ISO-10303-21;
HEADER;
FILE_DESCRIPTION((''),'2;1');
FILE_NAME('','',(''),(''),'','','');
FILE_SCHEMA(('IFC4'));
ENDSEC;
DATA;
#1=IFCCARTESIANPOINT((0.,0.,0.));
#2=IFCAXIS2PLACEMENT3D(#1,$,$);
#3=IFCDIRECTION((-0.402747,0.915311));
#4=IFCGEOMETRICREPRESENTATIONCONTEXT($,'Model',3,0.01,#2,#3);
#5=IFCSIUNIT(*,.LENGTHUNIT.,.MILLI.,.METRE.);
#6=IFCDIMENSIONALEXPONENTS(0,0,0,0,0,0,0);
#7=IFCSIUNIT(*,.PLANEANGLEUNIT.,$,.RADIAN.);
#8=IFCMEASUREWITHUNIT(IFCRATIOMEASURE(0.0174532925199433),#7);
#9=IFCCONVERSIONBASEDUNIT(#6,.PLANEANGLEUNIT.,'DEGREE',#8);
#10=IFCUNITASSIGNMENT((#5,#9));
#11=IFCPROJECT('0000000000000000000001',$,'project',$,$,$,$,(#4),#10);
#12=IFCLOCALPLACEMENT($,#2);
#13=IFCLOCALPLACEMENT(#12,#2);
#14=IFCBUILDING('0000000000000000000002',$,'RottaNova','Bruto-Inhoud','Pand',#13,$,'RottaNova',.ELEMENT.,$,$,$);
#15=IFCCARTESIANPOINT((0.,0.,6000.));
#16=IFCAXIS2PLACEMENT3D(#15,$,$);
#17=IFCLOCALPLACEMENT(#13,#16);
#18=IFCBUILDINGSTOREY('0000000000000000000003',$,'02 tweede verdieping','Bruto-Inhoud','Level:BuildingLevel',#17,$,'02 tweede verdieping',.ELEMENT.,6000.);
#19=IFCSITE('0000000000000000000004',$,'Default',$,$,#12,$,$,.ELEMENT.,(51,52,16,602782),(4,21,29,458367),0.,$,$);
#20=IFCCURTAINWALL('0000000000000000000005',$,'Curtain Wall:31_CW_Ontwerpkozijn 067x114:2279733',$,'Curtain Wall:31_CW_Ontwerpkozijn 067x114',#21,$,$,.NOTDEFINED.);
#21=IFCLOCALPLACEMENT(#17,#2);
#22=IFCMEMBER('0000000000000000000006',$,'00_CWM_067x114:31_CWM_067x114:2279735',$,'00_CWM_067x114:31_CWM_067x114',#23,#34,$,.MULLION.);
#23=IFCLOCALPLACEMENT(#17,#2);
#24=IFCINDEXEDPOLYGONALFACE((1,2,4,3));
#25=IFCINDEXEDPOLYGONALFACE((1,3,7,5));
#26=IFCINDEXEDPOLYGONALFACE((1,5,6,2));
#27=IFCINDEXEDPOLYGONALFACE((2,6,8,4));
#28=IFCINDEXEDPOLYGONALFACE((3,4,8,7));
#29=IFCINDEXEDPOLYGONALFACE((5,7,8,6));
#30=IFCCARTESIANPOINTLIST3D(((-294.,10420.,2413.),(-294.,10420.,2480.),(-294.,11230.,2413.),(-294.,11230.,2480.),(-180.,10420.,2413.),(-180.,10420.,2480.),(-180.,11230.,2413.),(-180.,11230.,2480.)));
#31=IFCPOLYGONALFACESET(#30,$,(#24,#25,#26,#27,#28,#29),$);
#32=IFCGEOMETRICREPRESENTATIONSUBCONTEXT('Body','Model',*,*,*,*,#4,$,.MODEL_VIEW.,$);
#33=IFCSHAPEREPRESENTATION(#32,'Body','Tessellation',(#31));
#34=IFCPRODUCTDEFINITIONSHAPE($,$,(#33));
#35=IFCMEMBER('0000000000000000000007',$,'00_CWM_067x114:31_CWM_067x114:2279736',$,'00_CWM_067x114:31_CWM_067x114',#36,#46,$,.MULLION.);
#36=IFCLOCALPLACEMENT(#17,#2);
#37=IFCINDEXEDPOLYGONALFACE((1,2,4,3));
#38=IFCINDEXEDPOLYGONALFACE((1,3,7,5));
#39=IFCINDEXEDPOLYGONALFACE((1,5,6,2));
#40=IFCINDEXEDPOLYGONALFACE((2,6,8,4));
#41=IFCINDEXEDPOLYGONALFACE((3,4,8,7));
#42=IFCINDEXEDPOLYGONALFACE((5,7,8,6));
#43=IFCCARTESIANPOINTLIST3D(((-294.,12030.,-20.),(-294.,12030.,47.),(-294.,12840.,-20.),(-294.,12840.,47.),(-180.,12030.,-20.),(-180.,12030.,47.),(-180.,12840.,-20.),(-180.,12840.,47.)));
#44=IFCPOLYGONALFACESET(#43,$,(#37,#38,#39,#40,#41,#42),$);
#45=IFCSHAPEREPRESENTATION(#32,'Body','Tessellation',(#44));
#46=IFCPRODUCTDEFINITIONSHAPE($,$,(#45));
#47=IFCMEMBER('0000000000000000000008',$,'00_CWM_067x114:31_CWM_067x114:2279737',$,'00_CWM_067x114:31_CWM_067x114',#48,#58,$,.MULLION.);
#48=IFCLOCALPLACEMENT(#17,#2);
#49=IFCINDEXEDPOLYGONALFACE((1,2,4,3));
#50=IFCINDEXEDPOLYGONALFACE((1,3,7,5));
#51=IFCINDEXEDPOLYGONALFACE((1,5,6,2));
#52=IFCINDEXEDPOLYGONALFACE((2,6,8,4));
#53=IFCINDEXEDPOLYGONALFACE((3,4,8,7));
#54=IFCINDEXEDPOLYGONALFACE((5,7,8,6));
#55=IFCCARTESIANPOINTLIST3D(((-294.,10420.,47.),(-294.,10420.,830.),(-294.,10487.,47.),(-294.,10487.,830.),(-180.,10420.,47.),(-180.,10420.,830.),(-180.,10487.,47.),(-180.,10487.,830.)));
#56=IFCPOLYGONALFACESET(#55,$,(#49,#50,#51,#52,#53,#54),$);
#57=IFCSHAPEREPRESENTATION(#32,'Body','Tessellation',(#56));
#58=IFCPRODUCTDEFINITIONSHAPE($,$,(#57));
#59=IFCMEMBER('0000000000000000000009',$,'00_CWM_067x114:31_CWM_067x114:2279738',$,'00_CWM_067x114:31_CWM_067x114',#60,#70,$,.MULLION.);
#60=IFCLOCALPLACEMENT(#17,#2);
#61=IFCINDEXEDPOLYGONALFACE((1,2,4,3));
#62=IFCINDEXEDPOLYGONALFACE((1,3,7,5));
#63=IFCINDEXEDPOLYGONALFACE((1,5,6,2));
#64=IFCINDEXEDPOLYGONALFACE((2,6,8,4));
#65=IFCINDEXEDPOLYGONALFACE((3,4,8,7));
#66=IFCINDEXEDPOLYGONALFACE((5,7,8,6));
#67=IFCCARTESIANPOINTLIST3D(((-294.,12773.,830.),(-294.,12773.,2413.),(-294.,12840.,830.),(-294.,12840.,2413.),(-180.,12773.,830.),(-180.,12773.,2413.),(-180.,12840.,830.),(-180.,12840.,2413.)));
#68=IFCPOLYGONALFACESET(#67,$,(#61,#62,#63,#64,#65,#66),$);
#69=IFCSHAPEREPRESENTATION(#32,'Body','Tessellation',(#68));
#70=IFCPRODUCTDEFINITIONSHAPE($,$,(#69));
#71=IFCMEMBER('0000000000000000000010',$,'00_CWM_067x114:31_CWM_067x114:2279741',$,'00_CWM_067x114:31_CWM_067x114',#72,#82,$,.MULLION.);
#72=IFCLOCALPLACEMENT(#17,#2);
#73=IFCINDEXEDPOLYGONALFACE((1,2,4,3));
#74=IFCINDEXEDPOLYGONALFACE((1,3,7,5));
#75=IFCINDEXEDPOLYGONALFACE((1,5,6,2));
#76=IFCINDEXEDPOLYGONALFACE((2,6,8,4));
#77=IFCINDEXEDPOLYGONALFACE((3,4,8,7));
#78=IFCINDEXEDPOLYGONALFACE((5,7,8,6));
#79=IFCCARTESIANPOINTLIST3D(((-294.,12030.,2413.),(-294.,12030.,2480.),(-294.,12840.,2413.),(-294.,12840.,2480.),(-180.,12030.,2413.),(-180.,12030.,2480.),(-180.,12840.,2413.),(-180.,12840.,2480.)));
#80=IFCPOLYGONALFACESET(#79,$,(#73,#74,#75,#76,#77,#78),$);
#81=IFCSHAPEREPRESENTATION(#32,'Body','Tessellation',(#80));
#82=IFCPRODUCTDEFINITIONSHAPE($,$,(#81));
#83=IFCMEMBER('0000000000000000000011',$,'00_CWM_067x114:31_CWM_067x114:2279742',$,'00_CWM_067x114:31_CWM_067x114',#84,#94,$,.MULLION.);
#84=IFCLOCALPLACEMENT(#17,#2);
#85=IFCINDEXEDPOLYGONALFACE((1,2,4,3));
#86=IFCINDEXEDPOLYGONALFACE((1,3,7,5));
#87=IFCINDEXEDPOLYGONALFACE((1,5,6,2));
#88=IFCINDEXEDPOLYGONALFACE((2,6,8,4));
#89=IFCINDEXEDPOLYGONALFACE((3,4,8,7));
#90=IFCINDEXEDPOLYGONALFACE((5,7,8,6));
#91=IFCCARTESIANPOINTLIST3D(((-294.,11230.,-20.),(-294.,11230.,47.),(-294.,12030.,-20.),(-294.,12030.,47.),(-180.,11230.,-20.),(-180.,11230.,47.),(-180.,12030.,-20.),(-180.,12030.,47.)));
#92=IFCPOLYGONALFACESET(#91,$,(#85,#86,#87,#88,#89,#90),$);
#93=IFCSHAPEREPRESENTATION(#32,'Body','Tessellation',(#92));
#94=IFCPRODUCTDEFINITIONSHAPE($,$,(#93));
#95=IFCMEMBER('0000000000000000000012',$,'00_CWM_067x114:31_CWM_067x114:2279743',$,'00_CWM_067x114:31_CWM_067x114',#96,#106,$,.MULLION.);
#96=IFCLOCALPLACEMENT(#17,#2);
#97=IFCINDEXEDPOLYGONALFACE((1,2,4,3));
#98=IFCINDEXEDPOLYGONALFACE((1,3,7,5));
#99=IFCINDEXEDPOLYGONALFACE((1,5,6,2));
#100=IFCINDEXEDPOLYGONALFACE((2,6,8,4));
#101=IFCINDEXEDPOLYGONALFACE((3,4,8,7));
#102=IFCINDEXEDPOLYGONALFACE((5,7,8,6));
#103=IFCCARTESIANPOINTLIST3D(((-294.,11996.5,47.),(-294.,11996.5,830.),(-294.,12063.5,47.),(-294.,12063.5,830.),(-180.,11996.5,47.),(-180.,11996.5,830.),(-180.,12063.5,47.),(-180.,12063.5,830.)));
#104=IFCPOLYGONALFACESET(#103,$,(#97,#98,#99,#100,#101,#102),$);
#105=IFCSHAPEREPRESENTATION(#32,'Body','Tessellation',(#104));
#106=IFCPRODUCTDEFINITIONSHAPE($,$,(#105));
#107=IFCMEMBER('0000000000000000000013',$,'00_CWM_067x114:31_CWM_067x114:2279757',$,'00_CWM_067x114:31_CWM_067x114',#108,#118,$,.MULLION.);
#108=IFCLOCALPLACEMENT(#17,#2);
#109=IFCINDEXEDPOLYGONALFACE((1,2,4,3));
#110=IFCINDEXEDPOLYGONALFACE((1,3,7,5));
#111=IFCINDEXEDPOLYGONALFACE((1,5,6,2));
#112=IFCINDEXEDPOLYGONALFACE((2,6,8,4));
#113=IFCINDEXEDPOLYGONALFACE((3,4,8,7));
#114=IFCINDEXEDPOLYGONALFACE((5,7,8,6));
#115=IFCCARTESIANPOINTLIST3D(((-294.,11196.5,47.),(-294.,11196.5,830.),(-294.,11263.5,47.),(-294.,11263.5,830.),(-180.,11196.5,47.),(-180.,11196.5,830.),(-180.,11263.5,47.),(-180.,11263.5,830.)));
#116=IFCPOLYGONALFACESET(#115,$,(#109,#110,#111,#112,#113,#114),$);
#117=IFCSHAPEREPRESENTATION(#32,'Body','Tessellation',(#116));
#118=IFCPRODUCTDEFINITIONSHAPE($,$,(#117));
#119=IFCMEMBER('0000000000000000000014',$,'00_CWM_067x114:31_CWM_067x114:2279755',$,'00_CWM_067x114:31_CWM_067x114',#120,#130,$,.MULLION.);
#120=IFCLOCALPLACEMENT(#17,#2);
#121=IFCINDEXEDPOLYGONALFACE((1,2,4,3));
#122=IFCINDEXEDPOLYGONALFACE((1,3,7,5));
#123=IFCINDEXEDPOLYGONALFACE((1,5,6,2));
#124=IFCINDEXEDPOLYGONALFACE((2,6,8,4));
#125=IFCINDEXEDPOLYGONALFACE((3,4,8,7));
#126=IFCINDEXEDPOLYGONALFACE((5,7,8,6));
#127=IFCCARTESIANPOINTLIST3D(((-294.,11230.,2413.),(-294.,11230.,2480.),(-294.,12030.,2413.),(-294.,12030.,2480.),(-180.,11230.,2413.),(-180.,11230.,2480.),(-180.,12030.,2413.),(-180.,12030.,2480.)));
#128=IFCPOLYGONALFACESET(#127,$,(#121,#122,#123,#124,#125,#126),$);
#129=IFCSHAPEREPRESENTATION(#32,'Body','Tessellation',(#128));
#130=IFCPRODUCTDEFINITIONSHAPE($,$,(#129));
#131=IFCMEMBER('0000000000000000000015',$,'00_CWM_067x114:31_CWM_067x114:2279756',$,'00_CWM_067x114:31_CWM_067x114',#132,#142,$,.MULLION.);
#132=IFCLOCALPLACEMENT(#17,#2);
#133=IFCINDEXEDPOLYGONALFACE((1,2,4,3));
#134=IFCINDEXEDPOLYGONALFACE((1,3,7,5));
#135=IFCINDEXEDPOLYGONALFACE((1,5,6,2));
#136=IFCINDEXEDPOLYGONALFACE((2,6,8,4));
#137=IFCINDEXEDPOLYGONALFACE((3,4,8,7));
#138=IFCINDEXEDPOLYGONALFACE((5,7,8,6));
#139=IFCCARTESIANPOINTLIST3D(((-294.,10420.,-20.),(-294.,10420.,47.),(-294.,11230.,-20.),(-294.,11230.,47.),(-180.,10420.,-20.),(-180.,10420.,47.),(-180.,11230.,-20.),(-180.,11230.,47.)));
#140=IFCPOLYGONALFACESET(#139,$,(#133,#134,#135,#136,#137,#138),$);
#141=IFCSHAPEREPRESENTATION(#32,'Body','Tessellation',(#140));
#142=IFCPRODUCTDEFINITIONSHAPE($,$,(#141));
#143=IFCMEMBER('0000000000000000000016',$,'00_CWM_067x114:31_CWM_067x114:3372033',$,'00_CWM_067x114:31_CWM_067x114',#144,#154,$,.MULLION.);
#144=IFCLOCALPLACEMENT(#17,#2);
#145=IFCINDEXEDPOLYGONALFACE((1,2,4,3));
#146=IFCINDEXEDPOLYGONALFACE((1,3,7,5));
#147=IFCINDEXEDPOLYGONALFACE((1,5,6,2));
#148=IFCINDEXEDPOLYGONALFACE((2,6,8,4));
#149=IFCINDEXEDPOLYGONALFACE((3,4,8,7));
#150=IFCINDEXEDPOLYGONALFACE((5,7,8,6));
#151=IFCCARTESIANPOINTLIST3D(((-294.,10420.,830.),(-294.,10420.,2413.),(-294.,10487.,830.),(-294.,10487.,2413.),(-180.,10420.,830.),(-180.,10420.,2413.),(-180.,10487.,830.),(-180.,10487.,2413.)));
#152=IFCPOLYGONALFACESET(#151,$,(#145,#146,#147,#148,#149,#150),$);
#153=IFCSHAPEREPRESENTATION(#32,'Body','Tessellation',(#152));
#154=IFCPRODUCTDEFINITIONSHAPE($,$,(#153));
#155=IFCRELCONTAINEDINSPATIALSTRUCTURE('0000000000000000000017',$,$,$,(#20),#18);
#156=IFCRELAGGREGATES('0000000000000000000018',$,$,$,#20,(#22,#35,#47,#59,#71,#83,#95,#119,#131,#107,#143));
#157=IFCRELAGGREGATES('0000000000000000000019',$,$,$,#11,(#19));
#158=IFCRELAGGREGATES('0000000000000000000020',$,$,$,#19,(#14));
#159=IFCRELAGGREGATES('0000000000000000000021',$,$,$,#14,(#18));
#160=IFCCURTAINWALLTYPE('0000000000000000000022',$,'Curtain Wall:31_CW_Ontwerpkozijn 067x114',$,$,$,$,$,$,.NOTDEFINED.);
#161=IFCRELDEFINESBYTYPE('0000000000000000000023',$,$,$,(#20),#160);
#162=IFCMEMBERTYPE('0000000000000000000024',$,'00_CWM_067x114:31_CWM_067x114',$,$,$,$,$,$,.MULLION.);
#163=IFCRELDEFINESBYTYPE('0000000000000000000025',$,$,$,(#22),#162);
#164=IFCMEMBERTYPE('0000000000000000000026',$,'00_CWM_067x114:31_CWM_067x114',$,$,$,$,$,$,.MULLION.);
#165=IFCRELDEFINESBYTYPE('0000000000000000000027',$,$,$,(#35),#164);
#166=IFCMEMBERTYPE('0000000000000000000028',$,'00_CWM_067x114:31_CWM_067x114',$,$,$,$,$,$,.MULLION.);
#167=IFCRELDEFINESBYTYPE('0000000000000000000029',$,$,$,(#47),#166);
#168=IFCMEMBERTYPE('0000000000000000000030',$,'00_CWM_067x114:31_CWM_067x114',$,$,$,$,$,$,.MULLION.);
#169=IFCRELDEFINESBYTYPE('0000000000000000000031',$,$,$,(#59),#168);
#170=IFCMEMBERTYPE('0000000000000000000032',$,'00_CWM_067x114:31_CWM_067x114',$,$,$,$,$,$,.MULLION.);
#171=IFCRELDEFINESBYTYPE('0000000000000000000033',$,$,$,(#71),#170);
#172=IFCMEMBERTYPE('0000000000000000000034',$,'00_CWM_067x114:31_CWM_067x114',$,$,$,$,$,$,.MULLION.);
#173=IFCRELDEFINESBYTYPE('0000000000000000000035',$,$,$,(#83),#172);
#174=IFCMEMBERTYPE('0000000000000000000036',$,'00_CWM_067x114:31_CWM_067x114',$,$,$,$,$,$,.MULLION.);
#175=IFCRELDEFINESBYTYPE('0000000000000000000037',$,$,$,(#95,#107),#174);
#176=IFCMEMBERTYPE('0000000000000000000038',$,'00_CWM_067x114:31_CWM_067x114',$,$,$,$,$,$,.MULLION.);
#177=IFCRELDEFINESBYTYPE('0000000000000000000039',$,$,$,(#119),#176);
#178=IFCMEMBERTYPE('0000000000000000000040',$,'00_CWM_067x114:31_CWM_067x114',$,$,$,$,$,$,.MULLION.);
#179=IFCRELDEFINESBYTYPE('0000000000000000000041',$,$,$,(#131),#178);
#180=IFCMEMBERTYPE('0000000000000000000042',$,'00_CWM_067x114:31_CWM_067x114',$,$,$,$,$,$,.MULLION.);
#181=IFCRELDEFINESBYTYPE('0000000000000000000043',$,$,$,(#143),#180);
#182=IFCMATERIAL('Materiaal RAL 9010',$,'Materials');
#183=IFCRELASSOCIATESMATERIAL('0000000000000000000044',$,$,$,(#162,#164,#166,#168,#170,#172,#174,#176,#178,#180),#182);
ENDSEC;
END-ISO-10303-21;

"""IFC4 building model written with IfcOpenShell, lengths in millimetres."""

from ifc_helpers import new_model, entity, si_unit, converted_unit, direction, frame, origin, origin_2d_with_axis, place, context, subcontext, project, spatial, rectangle, extrude, source, transform, mapped, material, material_profile, profile_set, type_object, type_shapes, element, aggregate, save


model = new_model("IFC4")

# Units and contexts
model_context = context("Model", 3, precision=0.01, world=origin(), true_north=direction((-0.402747, 0.915311)))
body_context = subcontext(model_context, "Body", "Model", "MODEL_VIEW")
ifc_project = project(units=[si_unit("LENGTHUNIT", "METRE", prefix="MILLI"), converted_unit("PLANEANGLEUNIT", "DEGREE", entity("IfcRatioMeasure", 0.0174532925199433), si_unit("PLANEANGLEUNIT", "RADIAN"), dimensions=[0, 0, 0, 0, 0, 0, 0])], contexts=[model_context])

# Site, building, storey
site_placement = place(None, origin())
site = spatial("IfcSite", under=ifc_project, at=site_placement, Name="Default", CompositionType="ELEMENT", RefLatitude=(51, 52, 16, 602782), RefLongitude=(4, 21, 29, 458367), RefElevation=0.0)
building_placement = place(site_placement, origin())
building = spatial("IfcBuilding", under=site, at=building_placement, Name="RottaNova", Description="Bruto-Inhoud", ObjectType="Pand", LongName="RottaNova", CompositionType="ELEMENT")
storey_placement = place(building_placement, frame((0.0, 0.0, 6000.0)))
storey = spatial("IfcBuildingStorey", under=building, at=storey_placement, Name="02 tweede verdieping", Description="Bruto-Inhoud", ObjectType="Level:BuildingLevel", LongName="02 tweede verdieping", CompositionType="ELEMENT", Elevation=6000.0)

# Curtain wall, members
curtain_wall_type = type_object("IfcCurtainWallType", Name="Curtain Wall:31_CW_Ontwerpkozijn 067x114", PredefinedType="NOTDEFINED")
curtain_wall_1_placement = place(storey_placement, frame((0.0, 0.0, -6000.0)))
curtain_wall_1 = element("IfcCurtainWall", 1, at=curtain_wall_1_placement, inside=storey, type_object=curtain_wall_type, Name="Curtain Wall:31_CW_Ontwerpkozijn 067x114:2279733", ObjectType="Curtain Wall:31_CW_Ontwerpkozijn 067x114", PredefinedType="NOTDEFINED")
ifc_material_1 = material(Name="Materiaal RAL 9010", Category="Materials")
ifc_material_profile = material_profile(ifc_material_1, rectangle(XDim=114.0, YDim=67.0, at=origin_2d_with_axis()), Name="31_CWM_067x114")
ifc_profile_set = profile_set([ifc_material_profile], Name="31_CWM_067x114")
member_type_1 = type_object("IfcMemberType", Name="00_CWM_067x114:31_CWM_067x114", PredefinedType="MULLION", material=ifc_profile_set)
shared_shape_1 = source(origin(), body_context, "Body", "SweptSolid", [
    extrude(rectangle(XDim=114.0, YDim=67.0, at=origin_2d_with_axis()), frame((-33.5, 57.0, -810.0), z_axis=(0.0, 0.0, 1.0), x_axis=(0.0, -1.0, 0.0)), (0.0, 0.0, 1.0), 810.0),
])
type_shapes(member_type_1, [shared_shape_1])
member_1_placement = place(curtain_wall_1_placement, frame((-180.0, 10420.0, 8480.0), z_axis=(0.0, -1.0, 0.0), x_axis=(0.0, 0.0, 1.0)))
member_1 = element("IfcMember", 2, at=member_1_placement, type_object=member_type_1, Name="00_CWM_067x114:31_CWM_067x114:2279735", ObjectType="00_CWM_067x114:31_CWM_067x114", PredefinedType="MULLION", context=body_context, shape_type="MappedRepresentation", body=[
    mapped(shared_shape_1, transform((0.0, 0.0, 0.0), scale=1.0)),
])
member_type_2 = type_object("IfcMemberType", Name="00_CWM_067x114:31_CWM_067x114", PredefinedType="MULLION", material=ifc_profile_set)
shared_shape_2 = source(origin(), body_context, "Body", "SweptSolid", [
    extrude(rectangle(XDim=114.0, YDim=67.0, at=origin_2d_with_axis()), frame((-33.5, 57.0, -810.0), z_axis=(0.0, 0.0, 1.0), x_axis=(0.0, -1.0, 0.0)), (0.0, 0.0, 1.0), 810.0),
])
type_shapes(member_type_2, [shared_shape_2])
member_2_placement = place(curtain_wall_1_placement, frame((-180.0, 12840.0, 5980.0), z_axis=(0.0, 1.0, 0.0), x_axis=(0.0, 0.0, -1.0)))
member_2 = element("IfcMember", 3, at=member_2_placement, type_object=member_type_2, Name="00_CWM_067x114:31_CWM_067x114:2279736", ObjectType="00_CWM_067x114:31_CWM_067x114", PredefinedType="MULLION", context=body_context, shape_type="MappedRepresentation", body=[
    mapped(shared_shape_2, transform((0.0, 0.0, 0.0), scale=1.0)),
])
member_type_3 = type_object("IfcMemberType", Name="00_CWM_067x114:31_CWM_067x114", PredefinedType="MULLION", material=ifc_profile_set)
shared_shape_3 = source(origin(), body_context, "Body", "SweptSolid", [
    extrude(rectangle(XDim=114.0, YDim=67.0, at=origin_2d_with_axis()), frame((-33.5, 57.0, -783.0), z_axis=(0.0, 0.0, 1.0), x_axis=(0.0, -1.0, 0.0)), (0.0, 0.0, 1.0), 783.0),
])
type_shapes(member_type_3, [shared_shape_3])
member_3_placement = place(curtain_wall_1_placement, frame((-180.0, 10420.0, 6047.0), z_axis=(0.0, 0.0, -1.0), x_axis=(0.0, -1.0, 0.0)))
member_3 = element("IfcMember", 4, at=member_3_placement, type_object=member_type_3, Name="00_CWM_067x114:31_CWM_067x114:2279737", ObjectType="00_CWM_067x114:31_CWM_067x114", PredefinedType="MULLION", context=body_context, shape_type="MappedRepresentation", body=[
    mapped(shared_shape_3, transform((0.0, 0.0, 0.0), scale=1.0)),
])
member_type_4 = type_object("IfcMemberType", Name="00_CWM_067x114:31_CWM_067x114", PredefinedType="MULLION", material=ifc_profile_set)
shared_shape_4 = source(origin(), body_context, "Body", "SweptSolid", [
    extrude(rectangle(XDim=114.0, YDim=67.0, at=origin_2d_with_axis()), frame((-33.5, 57.0, -1583.0), z_axis=(0.0, 0.0, 1.0), x_axis=(0.0, -1.0, 0.0)), (0.0, 0.0, 1.0), 1583.0),
])
type_shapes(member_type_4, [shared_shape_4])
member_4_placement = place(curtain_wall_1_placement, frame((-180.0, 12840.0, 8413.0), z_axis=(0.0, 0.0, 1.0), x_axis=(0.0, 1.0, 0.0)))
member_4 = element("IfcMember", 5, at=member_4_placement, type_object=member_type_4, Name="00_CWM_067x114:31_CWM_067x114:2279738", ObjectType="00_CWM_067x114:31_CWM_067x114", PredefinedType="MULLION", context=body_context, shape_type="MappedRepresentation", body=[
    mapped(shared_shape_4, transform((0.0, 0.0, 0.0), scale=1.0)),
])
member_type_5 = type_object("IfcMemberType", Name="00_CWM_067x114:31_CWM_067x114", PredefinedType="MULLION", material=ifc_profile_set)
shared_shape_5 = source(origin(), body_context, "Body", "SweptSolid", [
    extrude(rectangle(XDim=114.0, YDim=67.0, at=origin_2d_with_axis()), frame((-33.5, 57.0, -810.0), z_axis=(0.0, 0.0, 1.0), x_axis=(0.0, -1.0, 0.0)), (0.0, 0.0, 1.0), 810.0),
])
type_shapes(member_type_5, [shared_shape_5])
member_5_placement = place(curtain_wall_1_placement, frame((-180.0, 12030.0, 8480.0), z_axis=(0.0, -1.0, 0.0), x_axis=(0.0, 0.0, 1.0)))
member_5 = element("IfcMember", 6, at=member_5_placement, type_object=member_type_5, Name="00_CWM_067x114:31_CWM_067x114:2279741", ObjectType="00_CWM_067x114:31_CWM_067x114", PredefinedType="MULLION", context=body_context, shape_type="MappedRepresentation", body=[
    mapped(shared_shape_5, transform((0.0, 0.0, 0.0), scale=1.0)),
])
member_type_6 = type_object("IfcMemberType", Name="00_CWM_067x114:31_CWM_067x114", PredefinedType="MULLION", material=ifc_profile_set)
shared_shape_6 = source(origin(), body_context, "Body", "SweptSolid", [
    extrude(rectangle(XDim=114.0, YDim=67.0, at=origin_2d_with_axis()), frame((-33.5, 57.0, -800.0), z_axis=(0.0, 0.0, 1.0), x_axis=(0.0, -1.0, 0.0)), (0.0, 0.0, 1.0), 800.0),
])
type_shapes(member_type_6, [shared_shape_6])
member_6_placement = place(curtain_wall_1_placement, frame((-180.0, 12030.0, 5980.0), z_axis=(0.0, 1.0, 0.0), x_axis=(0.0, 0.0, -1.0)))
member_6 = element("IfcMember", 7, at=member_6_placement, type_object=member_type_6, Name="00_CWM_067x114:31_CWM_067x114:2279742", ObjectType="00_CWM_067x114:31_CWM_067x114", PredefinedType="MULLION", context=body_context, shape_type="MappedRepresentation", body=[
    mapped(shared_shape_6, transform((0.0, 0.0, 0.0), scale=1.0)),
])
member_type_7 = type_object("IfcMemberType", Name="00_CWM_067x114:31_CWM_067x114", PredefinedType="MULLION", material=ifc_profile_set)
shared_shape_7 = source(origin(), body_context, "Body", "SweptSolid", [
    extrude(rectangle(XDim=114.0, YDim=67.0, at=origin_2d_with_axis()), frame((0.0, 57.0, -783.0), z_axis=(0.0, 0.0, 1.0), x_axis=(0.0, -1.0, 0.0)), (0.0, 0.0, 1.0), 783.0),
])
type_shapes(member_type_7, [shared_shape_7])
member_7_placement = place(curtain_wall_1_placement, frame((-180.0, 12030.0, 6047.0), z_axis=(0.0, 0.0, -1.0), x_axis=(0.0, -1.0, 0.0)))
member_7 = element("IfcMember", 8, at=member_7_placement, type_object=member_type_7, Name="00_CWM_067x114:31_CWM_067x114:2279743", ObjectType="00_CWM_067x114:31_CWM_067x114", PredefinedType="MULLION", context=body_context, shape_type="MappedRepresentation", body=[
    mapped(shared_shape_7, transform((0.0, 0.0, 0.0), scale=1.0)),
])
member_8_placement = place(curtain_wall_1_placement, frame((-180.0, 11230.0, 6047.0), z_axis=(0.0, 0.0, -1.0), x_axis=(0.0, -1.0, 0.0)))
member_8 = element("IfcMember", 9, at=member_8_placement, type_object=member_type_7, Name="00_CWM_067x114:31_CWM_067x114:2279757", ObjectType="00_CWM_067x114:31_CWM_067x114", PredefinedType="MULLION", context=body_context, shape_type="MappedRepresentation", body=[
    mapped(shared_shape_7, transform((0.0, 0.0, 0.0), scale=1.0)),
])
member_type_8 = type_object("IfcMemberType", Name="00_CWM_067x114:31_CWM_067x114", PredefinedType="MULLION", material=ifc_profile_set)
shared_shape_8 = source(origin(), body_context, "Body", "SweptSolid", [
    extrude(rectangle(XDim=114.0, YDim=67.0, at=origin_2d_with_axis()), frame((-33.5, 57.0, -800.0), z_axis=(0.0, 0.0, 1.0), x_axis=(0.0, -1.0, 0.0)), (0.0, 0.0, 1.0), 800.0),
])
type_shapes(member_type_8, [shared_shape_8])
member_9_placement = place(curtain_wall_1_placement, frame((-180.0, 11230.0, 8480.0), z_axis=(0.0, -1.0, 0.0), x_axis=(0.0, 0.0, 1.0)))
member_9 = element("IfcMember", 10, at=member_9_placement, type_object=member_type_8, Name="00_CWM_067x114:31_CWM_067x114:2279755", ObjectType="00_CWM_067x114:31_CWM_067x114", PredefinedType="MULLION", context=body_context, shape_type="MappedRepresentation", body=[
    mapped(shared_shape_8, transform((0.0, 0.0, 0.0), scale=1.0)),
])
member_type_9 = type_object("IfcMemberType", Name="00_CWM_067x114:31_CWM_067x114", PredefinedType="MULLION", material=ifc_profile_set)
shared_shape_9 = source(origin(), body_context, "Body", "SweptSolid", [
    extrude(rectangle(XDim=114.0, YDim=67.0, at=origin_2d_with_axis()), frame((-33.5, 57.0, -810.0), z_axis=(0.0, 0.0, 1.0), x_axis=(0.0, -1.0, 0.0)), (0.0, 0.0, 1.0), 810.0),
])
type_shapes(member_type_9, [shared_shape_9])
member_10_placement = place(curtain_wall_1_placement, frame((-180.0, 11230.0, 5980.0), z_axis=(0.0, 1.0, 0.0), x_axis=(0.0, 0.0, -1.0)))
member_10 = element("IfcMember", 11, at=member_10_placement, type_object=member_type_9, Name="00_CWM_067x114:31_CWM_067x114:2279756", ObjectType="00_CWM_067x114:31_CWM_067x114", PredefinedType="MULLION", context=body_context, shape_type="MappedRepresentation", body=[
    mapped(shared_shape_9, transform((0.0, 0.0, 0.0), scale=1.0)),
])
member_type_10 = type_object("IfcMemberType", Name="00_CWM_067x114:31_CWM_067x114", PredefinedType="MULLION", material=ifc_profile_set)
shared_shape_10 = source(origin(), body_context, "Body", "SweptSolid", [
    extrude(rectangle(XDim=114.0, YDim=67.0, at=origin_2d_with_axis()), frame((-33.5, 57.0, -1583.0), z_axis=(0.0, 0.0, 1.0), x_axis=(0.0, -1.0, 0.0)), (0.0, 0.0, 1.0), 1583.0),
])
type_shapes(member_type_10, [shared_shape_10])
member_11_placement = place(curtain_wall_1_placement, frame((-180.0, 10420.0, 6830.0), z_axis=(0.0, 0.0, -1.0), x_axis=(0.0, -1.0, 0.0)))
member_11 = element("IfcMember", 12, at=member_11_placement, type_object=member_type_10, Name="00_CWM_067x114:31_CWM_067x114:3372033", ObjectType="00_CWM_067x114:31_CWM_067x114", PredefinedType="MULLION", context=body_context, shape_type="MappedRepresentation", body=[
    mapped(shared_shape_10, transform((0.0, 0.0, 0.0), scale=1.0)),
])

aggregate(curtain_wall_1, [member_1, member_2, member_3, member_4, member_5, member_6, member_7, member_9, member_10, member_8, member_11])

save(model, "model.ifc")
